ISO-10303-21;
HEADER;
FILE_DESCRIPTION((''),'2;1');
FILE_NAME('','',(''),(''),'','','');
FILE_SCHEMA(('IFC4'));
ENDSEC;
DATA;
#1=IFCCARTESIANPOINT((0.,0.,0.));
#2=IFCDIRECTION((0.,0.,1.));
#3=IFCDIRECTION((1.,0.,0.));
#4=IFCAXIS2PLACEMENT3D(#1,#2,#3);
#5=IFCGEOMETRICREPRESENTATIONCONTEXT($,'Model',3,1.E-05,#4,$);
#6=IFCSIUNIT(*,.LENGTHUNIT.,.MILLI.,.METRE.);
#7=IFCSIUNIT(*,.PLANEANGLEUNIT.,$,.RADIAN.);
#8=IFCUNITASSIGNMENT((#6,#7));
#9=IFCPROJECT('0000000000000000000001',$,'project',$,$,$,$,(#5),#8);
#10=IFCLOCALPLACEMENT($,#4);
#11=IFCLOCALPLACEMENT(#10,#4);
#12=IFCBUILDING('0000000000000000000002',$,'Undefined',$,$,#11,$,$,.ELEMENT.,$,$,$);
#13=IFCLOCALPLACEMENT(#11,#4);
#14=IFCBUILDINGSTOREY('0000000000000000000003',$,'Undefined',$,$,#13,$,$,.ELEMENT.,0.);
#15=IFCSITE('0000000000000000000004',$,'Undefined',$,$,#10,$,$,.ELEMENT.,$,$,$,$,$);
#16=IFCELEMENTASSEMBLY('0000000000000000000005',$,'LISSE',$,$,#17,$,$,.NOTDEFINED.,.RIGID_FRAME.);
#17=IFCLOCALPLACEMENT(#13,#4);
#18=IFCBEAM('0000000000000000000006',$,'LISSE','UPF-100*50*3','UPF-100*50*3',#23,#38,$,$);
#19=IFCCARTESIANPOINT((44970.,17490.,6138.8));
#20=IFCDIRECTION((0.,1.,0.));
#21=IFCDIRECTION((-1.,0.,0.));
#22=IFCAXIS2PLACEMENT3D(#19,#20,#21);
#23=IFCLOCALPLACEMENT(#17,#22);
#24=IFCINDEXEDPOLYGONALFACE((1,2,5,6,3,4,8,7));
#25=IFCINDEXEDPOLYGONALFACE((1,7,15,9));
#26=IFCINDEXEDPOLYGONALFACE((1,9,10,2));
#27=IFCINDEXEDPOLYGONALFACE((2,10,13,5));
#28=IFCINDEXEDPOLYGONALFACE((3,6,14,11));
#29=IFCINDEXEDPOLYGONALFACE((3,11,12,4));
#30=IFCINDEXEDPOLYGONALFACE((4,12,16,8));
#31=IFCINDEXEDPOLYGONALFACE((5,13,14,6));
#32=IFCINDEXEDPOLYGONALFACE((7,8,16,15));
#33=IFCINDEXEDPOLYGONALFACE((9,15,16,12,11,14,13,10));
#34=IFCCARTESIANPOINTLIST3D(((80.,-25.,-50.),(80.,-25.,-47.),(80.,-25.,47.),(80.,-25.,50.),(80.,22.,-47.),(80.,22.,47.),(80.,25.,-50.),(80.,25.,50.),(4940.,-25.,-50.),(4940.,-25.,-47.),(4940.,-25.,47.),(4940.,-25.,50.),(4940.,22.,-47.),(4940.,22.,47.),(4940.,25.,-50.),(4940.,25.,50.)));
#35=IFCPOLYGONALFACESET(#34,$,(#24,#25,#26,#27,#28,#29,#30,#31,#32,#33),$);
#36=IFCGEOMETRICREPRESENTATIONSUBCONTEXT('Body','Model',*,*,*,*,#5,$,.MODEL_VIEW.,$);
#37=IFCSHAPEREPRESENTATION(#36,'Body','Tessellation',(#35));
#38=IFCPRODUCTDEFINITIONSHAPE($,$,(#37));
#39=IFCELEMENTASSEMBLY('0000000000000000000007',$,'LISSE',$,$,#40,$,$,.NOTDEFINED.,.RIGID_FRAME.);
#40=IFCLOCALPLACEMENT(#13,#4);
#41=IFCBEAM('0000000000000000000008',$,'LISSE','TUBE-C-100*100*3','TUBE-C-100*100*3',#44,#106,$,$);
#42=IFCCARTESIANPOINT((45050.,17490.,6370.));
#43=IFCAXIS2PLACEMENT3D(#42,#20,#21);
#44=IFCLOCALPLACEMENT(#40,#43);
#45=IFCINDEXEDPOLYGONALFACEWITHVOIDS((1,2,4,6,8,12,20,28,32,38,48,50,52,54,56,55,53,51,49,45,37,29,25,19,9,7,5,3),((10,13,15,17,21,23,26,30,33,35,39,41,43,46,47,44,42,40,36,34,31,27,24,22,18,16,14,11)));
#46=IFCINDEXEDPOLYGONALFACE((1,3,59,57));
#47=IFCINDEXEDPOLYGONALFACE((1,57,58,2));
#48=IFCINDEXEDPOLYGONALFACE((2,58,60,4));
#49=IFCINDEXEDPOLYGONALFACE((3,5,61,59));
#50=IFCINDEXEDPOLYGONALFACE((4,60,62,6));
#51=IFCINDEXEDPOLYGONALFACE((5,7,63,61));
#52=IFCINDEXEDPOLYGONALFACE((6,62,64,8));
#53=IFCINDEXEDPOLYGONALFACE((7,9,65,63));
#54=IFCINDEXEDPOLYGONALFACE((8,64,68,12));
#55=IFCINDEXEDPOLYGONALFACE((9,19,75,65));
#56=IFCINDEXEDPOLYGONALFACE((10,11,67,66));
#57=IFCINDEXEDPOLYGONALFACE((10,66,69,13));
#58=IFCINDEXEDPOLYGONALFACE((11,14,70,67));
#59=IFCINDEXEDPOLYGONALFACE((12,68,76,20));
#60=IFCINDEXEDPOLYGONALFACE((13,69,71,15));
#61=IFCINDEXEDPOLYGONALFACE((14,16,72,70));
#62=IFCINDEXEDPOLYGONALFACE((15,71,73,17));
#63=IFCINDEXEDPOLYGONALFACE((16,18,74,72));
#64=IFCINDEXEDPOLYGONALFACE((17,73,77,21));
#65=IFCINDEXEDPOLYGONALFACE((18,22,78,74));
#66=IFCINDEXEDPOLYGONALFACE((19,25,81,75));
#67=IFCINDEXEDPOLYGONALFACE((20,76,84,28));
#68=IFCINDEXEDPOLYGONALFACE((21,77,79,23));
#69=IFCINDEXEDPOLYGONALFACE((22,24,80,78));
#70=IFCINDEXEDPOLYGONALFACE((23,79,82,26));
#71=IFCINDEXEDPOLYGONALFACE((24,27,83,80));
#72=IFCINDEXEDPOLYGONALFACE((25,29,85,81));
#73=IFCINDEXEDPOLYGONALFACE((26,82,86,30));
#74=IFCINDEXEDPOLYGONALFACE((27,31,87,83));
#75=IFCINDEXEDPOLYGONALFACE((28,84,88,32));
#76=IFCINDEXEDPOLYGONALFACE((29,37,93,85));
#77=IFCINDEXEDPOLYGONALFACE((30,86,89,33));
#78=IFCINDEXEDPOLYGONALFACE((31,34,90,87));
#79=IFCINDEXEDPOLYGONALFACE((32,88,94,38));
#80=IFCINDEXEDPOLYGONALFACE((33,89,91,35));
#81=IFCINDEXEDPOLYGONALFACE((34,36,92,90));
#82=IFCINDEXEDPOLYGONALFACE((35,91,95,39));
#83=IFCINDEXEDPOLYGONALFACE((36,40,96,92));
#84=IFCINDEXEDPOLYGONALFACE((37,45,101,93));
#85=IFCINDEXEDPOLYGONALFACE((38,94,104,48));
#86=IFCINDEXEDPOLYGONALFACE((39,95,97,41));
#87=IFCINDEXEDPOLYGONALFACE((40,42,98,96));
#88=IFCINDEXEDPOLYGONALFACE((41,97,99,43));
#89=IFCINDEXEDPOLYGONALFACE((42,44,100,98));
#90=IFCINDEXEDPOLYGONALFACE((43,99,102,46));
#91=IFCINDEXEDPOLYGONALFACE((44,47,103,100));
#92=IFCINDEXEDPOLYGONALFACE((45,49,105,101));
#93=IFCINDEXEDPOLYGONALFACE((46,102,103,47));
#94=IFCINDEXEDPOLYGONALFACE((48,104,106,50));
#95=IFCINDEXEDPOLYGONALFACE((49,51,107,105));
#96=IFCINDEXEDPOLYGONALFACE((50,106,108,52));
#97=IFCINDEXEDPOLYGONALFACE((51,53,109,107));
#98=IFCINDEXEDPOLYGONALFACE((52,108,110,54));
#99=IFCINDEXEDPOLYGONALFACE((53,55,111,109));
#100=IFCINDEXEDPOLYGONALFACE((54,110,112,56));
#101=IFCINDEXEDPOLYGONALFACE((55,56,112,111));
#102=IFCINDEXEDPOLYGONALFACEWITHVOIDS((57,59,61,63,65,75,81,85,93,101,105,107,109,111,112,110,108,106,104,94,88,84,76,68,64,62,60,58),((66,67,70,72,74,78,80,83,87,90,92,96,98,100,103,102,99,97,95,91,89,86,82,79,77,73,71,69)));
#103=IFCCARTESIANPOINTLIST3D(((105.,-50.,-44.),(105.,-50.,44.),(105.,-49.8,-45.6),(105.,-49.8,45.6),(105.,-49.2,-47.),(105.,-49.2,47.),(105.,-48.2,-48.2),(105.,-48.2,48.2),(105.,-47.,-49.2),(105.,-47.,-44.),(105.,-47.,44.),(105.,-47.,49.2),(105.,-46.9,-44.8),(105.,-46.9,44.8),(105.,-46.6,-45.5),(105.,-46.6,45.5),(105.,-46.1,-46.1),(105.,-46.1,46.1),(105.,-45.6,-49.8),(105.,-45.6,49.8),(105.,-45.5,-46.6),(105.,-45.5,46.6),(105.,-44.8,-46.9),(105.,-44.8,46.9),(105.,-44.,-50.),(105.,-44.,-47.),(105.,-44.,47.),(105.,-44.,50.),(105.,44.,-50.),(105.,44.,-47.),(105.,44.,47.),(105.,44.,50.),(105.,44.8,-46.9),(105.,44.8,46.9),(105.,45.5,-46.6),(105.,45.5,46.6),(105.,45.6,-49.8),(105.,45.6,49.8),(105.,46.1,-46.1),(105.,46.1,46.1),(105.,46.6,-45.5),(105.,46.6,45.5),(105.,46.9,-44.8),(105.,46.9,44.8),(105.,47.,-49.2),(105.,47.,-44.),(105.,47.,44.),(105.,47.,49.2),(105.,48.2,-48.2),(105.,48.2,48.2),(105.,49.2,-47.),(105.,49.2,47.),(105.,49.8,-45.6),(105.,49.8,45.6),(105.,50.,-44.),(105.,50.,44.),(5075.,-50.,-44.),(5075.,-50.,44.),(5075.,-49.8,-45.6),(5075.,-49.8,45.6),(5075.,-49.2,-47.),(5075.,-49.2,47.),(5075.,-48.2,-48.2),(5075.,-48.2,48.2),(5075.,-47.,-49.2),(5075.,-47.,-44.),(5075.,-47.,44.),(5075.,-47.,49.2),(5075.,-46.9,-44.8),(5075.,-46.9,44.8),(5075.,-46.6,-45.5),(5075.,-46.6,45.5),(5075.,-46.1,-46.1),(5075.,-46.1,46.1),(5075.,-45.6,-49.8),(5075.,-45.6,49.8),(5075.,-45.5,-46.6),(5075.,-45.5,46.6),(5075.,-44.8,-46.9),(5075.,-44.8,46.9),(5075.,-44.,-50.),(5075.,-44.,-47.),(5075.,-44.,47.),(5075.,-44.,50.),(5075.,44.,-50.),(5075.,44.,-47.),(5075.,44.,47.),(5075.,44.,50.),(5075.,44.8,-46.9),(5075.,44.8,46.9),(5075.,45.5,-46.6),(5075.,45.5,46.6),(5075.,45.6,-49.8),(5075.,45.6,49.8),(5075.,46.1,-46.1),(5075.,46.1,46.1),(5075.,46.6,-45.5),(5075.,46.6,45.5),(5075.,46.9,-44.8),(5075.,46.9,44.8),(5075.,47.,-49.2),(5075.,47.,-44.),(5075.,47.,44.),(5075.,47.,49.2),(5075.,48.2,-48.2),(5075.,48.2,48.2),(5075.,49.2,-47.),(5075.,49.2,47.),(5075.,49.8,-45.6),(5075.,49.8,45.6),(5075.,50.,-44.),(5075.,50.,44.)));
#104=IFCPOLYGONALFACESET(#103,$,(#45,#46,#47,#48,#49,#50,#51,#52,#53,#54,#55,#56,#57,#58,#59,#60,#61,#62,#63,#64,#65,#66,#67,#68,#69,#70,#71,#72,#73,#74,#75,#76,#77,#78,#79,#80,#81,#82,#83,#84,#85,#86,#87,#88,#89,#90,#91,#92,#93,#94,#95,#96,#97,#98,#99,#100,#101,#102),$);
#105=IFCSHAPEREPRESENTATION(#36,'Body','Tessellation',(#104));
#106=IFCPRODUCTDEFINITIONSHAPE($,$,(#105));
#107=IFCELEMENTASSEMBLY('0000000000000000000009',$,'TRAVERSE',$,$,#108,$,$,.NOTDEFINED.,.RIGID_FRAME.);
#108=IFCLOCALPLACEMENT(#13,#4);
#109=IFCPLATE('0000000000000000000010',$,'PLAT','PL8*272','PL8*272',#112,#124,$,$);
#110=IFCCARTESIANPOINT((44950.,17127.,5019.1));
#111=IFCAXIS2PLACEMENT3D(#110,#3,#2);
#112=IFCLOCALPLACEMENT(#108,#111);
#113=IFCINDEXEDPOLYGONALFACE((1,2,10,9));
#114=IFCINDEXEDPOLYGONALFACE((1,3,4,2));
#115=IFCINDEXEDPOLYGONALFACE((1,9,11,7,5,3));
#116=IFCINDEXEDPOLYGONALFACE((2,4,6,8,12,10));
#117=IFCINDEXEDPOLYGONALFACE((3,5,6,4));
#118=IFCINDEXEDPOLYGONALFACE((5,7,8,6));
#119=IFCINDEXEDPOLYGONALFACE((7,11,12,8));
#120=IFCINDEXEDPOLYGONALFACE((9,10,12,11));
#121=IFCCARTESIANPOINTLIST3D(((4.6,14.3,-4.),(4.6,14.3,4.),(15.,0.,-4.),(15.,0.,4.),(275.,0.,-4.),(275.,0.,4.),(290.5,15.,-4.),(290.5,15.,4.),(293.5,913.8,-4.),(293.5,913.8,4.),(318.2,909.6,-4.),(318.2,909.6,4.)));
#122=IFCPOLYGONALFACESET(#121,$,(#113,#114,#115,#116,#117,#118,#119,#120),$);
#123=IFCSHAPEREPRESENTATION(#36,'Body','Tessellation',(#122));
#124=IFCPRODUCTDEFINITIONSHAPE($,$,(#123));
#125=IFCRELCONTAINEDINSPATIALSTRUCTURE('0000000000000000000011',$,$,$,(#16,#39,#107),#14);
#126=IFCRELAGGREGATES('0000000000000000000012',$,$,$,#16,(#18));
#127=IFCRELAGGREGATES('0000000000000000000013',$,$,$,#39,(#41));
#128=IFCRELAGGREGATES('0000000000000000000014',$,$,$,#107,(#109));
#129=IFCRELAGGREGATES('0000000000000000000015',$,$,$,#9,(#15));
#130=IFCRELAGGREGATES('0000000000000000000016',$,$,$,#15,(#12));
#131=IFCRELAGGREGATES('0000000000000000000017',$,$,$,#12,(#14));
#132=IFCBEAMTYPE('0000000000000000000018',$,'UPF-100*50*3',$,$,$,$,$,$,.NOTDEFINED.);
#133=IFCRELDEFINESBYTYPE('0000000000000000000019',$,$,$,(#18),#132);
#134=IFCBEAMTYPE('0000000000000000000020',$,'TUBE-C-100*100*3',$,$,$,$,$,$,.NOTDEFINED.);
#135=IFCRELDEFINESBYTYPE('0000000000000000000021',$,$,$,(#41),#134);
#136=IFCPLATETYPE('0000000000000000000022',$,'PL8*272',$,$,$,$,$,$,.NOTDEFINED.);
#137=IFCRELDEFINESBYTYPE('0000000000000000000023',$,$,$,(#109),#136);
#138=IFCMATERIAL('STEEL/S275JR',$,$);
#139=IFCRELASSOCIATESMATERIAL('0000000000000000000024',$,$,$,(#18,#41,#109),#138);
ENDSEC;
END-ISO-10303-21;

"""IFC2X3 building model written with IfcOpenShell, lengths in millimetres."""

from ifc_helpers import new_model, si_unit, frame, origin_with_axes, origin_2d_with_axis, place, context, subcontext, project, spatial, polyline, hollow_rectangle, u_section, outline, extrude, clip, halfspace, material, type_object, element, aggregate, save


model = new_model("IFC2X3")

# Units and contexts
model_context = context("Model", 3, precision=1e-05, world=origin_with_axes())
body_context = subcontext(model_context, "Body", "Model", "MODEL_VIEW")
ifc_project = project(units=[si_unit("LENGTHUNIT", "METRE", prefix="MILLI"), si_unit("PLANEANGLEUNIT", "RADIAN")], contexts=[model_context])

# Site, building, storey
site_placement = place(None, origin_with_axes())
site = spatial("IfcSite", under=ifc_project, at=site_placement, Name="Undefined", CompositionType="ELEMENT")
building_placement = place(site_placement, origin_with_axes())
building = spatial("IfcBuilding", under=site, at=building_placement, Name="Undefined", CompositionType="ELEMENT")
storey_placement = place(building_placement, origin_with_axes())
storey = spatial("IfcBuildingStorey", under=building, at=storey_placement, Name="Undefined", CompositionType="ELEMENT", Elevation=0.0)

# Shared definitions
ifc_material_1 = material(Name="STEEL/S275JR")

# Element assemblies, beams
beam_type_1 = type_object("IfcBeamType", Name="UPF-100*50*3", PredefinedType="NOTDEFINED")
assembly_1_placement = place(storey_placement, origin_with_axes())
assembly_1 = element("IfcElementAssembly", 1, at=assembly_1_placement, inside=storey, Name="LISSE", AssemblyPlace="NOTDEFINED", PredefinedType="RIGID_FRAME")
beam_1_placement = place(assembly_1_placement, frame((44970.0, 17490.0, 6138.8), z_axis=(0.0, 1.0, 0.0), x_axis=(-1.0, 0.0, 0.0)))
beam_1 = element("IfcBeam", 2, at=beam_1_placement, type_object=beam_type_1, material=ifc_material_1, Name="LISSE", Description="UPF-100*50*3", ObjectType="UPF-100*50*3", context=body_context, shape_type="Clipping", body=[
    clip(clip(extrude(u_section(Depth=100.0, FlangeWidth=50.0, WebThickness=3.0, FlangeThickness=3.0, at=origin_2d_with_axis()), frame((4940.0, 0.0, 0.0), z_axis=(-1.0, 0.0, 0.0), x_axis=(0.0, -1.0, 0.0)), (0.0, 0.0, 1.0), 4860.0), halfspace(frame((4940.0, 41.3, 50.0), z_axis=(-1.0, 0.0, 0.0), x_axis=(0.0, 0.0, 1.0)), True)), halfspace(frame((80.0, 41.3, 50.0), z_axis=(1.0, 0.0, 0.0), x_axis=(0.0, -1.0, 0.0)), True)),
])
assembly_2_placement = place(storey_placement, origin_with_axes())
assembly_2 = element("IfcElementAssembly", 3, at=assembly_2_placement, inside=storey, Name="LISSE", AssemblyPlace="NOTDEFINED", PredefinedType="RIGID_FRAME")
beam_type_2 = type_object("IfcBeamType", Name="TUBE-C-100*100*3", PredefinedType="NOTDEFINED")
beam_2_placement = place(assembly_2_placement, frame((45050.0, 17490.0, 6370.0), z_axis=(0.0, 1.0, 0.0), x_axis=(-1.0, 0.0, 0.0)))
beam_2 = element("IfcBeam", 4, at=beam_2_placement, type_object=beam_type_2, material=ifc_material_1, Name="LISSE", Description="TUBE-C-100*100*3", ObjectType="TUBE-C-100*100*3", context=body_context, shape_type="Clipping", body=[
    clip(clip(extrude(hollow_rectangle(XDim=100.0, YDim=100.0, WallThickness=3.0, InnerFilletRadius=3.0, OuterFilletRadius=6.0, at=origin_2d_with_axis()), frame((5075.0, 0.0, 0.0), z_axis=(-1.0, 0.0, 0.0), x_axis=(0.0, -1.0, 0.0)), (0.0, 0.0, 1.0), 4970.0), halfspace(frame((5075.0, 121.7, 50.0), z_axis=(-1.0, 0.0, 0.0), x_axis=(0.0, 0.0, 1.0)), True)), halfspace(frame((105.0, -50.0, 59.0), z_axis=(1.0, 0.0, 0.0), x_axis=(0.0, 1.0, 0.0)), True)),
])

# Element assembly
assembly_3_placement = place(storey_placement, origin_with_axes())
assembly_3 = element("IfcElementAssembly", 5, at=assembly_3_placement, inside=storey, Name="TRAVERSE", AssemblyPlace="NOTDEFINED", PredefinedType="RIGID_FRAME")

# Plate
plate_type_1 = type_object("IfcPlateType", Name="PL8*272", PredefinedType="NOTDEFINED")
plate_1_placement = place(assembly_3_placement, frame((44950.0, 17127.0, 5019.1), z_axis=(1.0, 0.0, 0.0), x_axis=(0.0, 0.0, 1.0)))
plate_1 = element("IfcPlate", 6, at=plate_1_placement, type_object=plate_type_1, material=ifc_material_1, Name="PLAT", Description="PL8*272", ObjectType="PL8*272", context=body_context, shape_type="SweptSolid", body=[
    extrude(outline(polyline([(4.6, 14.3), (15.0, 0.0), (275.0, 0.0), (290.5, 15.0), (318.2, 909.6), (293.5, 913.8), (4.6, 14.3)])), frame((0.0, 0.0, -4.0), z_axis=(0.0, 0.0, 1.0), x_axis=(1.0, 0.0, 0.0)), (0.0, 0.0, 1.0), 8.0),
])

aggregate(assembly_1, [beam_1])

aggregate(assembly_2, [beam_2])

aggregate(assembly_3, [plate_1])

save(model, "model.ifc")
